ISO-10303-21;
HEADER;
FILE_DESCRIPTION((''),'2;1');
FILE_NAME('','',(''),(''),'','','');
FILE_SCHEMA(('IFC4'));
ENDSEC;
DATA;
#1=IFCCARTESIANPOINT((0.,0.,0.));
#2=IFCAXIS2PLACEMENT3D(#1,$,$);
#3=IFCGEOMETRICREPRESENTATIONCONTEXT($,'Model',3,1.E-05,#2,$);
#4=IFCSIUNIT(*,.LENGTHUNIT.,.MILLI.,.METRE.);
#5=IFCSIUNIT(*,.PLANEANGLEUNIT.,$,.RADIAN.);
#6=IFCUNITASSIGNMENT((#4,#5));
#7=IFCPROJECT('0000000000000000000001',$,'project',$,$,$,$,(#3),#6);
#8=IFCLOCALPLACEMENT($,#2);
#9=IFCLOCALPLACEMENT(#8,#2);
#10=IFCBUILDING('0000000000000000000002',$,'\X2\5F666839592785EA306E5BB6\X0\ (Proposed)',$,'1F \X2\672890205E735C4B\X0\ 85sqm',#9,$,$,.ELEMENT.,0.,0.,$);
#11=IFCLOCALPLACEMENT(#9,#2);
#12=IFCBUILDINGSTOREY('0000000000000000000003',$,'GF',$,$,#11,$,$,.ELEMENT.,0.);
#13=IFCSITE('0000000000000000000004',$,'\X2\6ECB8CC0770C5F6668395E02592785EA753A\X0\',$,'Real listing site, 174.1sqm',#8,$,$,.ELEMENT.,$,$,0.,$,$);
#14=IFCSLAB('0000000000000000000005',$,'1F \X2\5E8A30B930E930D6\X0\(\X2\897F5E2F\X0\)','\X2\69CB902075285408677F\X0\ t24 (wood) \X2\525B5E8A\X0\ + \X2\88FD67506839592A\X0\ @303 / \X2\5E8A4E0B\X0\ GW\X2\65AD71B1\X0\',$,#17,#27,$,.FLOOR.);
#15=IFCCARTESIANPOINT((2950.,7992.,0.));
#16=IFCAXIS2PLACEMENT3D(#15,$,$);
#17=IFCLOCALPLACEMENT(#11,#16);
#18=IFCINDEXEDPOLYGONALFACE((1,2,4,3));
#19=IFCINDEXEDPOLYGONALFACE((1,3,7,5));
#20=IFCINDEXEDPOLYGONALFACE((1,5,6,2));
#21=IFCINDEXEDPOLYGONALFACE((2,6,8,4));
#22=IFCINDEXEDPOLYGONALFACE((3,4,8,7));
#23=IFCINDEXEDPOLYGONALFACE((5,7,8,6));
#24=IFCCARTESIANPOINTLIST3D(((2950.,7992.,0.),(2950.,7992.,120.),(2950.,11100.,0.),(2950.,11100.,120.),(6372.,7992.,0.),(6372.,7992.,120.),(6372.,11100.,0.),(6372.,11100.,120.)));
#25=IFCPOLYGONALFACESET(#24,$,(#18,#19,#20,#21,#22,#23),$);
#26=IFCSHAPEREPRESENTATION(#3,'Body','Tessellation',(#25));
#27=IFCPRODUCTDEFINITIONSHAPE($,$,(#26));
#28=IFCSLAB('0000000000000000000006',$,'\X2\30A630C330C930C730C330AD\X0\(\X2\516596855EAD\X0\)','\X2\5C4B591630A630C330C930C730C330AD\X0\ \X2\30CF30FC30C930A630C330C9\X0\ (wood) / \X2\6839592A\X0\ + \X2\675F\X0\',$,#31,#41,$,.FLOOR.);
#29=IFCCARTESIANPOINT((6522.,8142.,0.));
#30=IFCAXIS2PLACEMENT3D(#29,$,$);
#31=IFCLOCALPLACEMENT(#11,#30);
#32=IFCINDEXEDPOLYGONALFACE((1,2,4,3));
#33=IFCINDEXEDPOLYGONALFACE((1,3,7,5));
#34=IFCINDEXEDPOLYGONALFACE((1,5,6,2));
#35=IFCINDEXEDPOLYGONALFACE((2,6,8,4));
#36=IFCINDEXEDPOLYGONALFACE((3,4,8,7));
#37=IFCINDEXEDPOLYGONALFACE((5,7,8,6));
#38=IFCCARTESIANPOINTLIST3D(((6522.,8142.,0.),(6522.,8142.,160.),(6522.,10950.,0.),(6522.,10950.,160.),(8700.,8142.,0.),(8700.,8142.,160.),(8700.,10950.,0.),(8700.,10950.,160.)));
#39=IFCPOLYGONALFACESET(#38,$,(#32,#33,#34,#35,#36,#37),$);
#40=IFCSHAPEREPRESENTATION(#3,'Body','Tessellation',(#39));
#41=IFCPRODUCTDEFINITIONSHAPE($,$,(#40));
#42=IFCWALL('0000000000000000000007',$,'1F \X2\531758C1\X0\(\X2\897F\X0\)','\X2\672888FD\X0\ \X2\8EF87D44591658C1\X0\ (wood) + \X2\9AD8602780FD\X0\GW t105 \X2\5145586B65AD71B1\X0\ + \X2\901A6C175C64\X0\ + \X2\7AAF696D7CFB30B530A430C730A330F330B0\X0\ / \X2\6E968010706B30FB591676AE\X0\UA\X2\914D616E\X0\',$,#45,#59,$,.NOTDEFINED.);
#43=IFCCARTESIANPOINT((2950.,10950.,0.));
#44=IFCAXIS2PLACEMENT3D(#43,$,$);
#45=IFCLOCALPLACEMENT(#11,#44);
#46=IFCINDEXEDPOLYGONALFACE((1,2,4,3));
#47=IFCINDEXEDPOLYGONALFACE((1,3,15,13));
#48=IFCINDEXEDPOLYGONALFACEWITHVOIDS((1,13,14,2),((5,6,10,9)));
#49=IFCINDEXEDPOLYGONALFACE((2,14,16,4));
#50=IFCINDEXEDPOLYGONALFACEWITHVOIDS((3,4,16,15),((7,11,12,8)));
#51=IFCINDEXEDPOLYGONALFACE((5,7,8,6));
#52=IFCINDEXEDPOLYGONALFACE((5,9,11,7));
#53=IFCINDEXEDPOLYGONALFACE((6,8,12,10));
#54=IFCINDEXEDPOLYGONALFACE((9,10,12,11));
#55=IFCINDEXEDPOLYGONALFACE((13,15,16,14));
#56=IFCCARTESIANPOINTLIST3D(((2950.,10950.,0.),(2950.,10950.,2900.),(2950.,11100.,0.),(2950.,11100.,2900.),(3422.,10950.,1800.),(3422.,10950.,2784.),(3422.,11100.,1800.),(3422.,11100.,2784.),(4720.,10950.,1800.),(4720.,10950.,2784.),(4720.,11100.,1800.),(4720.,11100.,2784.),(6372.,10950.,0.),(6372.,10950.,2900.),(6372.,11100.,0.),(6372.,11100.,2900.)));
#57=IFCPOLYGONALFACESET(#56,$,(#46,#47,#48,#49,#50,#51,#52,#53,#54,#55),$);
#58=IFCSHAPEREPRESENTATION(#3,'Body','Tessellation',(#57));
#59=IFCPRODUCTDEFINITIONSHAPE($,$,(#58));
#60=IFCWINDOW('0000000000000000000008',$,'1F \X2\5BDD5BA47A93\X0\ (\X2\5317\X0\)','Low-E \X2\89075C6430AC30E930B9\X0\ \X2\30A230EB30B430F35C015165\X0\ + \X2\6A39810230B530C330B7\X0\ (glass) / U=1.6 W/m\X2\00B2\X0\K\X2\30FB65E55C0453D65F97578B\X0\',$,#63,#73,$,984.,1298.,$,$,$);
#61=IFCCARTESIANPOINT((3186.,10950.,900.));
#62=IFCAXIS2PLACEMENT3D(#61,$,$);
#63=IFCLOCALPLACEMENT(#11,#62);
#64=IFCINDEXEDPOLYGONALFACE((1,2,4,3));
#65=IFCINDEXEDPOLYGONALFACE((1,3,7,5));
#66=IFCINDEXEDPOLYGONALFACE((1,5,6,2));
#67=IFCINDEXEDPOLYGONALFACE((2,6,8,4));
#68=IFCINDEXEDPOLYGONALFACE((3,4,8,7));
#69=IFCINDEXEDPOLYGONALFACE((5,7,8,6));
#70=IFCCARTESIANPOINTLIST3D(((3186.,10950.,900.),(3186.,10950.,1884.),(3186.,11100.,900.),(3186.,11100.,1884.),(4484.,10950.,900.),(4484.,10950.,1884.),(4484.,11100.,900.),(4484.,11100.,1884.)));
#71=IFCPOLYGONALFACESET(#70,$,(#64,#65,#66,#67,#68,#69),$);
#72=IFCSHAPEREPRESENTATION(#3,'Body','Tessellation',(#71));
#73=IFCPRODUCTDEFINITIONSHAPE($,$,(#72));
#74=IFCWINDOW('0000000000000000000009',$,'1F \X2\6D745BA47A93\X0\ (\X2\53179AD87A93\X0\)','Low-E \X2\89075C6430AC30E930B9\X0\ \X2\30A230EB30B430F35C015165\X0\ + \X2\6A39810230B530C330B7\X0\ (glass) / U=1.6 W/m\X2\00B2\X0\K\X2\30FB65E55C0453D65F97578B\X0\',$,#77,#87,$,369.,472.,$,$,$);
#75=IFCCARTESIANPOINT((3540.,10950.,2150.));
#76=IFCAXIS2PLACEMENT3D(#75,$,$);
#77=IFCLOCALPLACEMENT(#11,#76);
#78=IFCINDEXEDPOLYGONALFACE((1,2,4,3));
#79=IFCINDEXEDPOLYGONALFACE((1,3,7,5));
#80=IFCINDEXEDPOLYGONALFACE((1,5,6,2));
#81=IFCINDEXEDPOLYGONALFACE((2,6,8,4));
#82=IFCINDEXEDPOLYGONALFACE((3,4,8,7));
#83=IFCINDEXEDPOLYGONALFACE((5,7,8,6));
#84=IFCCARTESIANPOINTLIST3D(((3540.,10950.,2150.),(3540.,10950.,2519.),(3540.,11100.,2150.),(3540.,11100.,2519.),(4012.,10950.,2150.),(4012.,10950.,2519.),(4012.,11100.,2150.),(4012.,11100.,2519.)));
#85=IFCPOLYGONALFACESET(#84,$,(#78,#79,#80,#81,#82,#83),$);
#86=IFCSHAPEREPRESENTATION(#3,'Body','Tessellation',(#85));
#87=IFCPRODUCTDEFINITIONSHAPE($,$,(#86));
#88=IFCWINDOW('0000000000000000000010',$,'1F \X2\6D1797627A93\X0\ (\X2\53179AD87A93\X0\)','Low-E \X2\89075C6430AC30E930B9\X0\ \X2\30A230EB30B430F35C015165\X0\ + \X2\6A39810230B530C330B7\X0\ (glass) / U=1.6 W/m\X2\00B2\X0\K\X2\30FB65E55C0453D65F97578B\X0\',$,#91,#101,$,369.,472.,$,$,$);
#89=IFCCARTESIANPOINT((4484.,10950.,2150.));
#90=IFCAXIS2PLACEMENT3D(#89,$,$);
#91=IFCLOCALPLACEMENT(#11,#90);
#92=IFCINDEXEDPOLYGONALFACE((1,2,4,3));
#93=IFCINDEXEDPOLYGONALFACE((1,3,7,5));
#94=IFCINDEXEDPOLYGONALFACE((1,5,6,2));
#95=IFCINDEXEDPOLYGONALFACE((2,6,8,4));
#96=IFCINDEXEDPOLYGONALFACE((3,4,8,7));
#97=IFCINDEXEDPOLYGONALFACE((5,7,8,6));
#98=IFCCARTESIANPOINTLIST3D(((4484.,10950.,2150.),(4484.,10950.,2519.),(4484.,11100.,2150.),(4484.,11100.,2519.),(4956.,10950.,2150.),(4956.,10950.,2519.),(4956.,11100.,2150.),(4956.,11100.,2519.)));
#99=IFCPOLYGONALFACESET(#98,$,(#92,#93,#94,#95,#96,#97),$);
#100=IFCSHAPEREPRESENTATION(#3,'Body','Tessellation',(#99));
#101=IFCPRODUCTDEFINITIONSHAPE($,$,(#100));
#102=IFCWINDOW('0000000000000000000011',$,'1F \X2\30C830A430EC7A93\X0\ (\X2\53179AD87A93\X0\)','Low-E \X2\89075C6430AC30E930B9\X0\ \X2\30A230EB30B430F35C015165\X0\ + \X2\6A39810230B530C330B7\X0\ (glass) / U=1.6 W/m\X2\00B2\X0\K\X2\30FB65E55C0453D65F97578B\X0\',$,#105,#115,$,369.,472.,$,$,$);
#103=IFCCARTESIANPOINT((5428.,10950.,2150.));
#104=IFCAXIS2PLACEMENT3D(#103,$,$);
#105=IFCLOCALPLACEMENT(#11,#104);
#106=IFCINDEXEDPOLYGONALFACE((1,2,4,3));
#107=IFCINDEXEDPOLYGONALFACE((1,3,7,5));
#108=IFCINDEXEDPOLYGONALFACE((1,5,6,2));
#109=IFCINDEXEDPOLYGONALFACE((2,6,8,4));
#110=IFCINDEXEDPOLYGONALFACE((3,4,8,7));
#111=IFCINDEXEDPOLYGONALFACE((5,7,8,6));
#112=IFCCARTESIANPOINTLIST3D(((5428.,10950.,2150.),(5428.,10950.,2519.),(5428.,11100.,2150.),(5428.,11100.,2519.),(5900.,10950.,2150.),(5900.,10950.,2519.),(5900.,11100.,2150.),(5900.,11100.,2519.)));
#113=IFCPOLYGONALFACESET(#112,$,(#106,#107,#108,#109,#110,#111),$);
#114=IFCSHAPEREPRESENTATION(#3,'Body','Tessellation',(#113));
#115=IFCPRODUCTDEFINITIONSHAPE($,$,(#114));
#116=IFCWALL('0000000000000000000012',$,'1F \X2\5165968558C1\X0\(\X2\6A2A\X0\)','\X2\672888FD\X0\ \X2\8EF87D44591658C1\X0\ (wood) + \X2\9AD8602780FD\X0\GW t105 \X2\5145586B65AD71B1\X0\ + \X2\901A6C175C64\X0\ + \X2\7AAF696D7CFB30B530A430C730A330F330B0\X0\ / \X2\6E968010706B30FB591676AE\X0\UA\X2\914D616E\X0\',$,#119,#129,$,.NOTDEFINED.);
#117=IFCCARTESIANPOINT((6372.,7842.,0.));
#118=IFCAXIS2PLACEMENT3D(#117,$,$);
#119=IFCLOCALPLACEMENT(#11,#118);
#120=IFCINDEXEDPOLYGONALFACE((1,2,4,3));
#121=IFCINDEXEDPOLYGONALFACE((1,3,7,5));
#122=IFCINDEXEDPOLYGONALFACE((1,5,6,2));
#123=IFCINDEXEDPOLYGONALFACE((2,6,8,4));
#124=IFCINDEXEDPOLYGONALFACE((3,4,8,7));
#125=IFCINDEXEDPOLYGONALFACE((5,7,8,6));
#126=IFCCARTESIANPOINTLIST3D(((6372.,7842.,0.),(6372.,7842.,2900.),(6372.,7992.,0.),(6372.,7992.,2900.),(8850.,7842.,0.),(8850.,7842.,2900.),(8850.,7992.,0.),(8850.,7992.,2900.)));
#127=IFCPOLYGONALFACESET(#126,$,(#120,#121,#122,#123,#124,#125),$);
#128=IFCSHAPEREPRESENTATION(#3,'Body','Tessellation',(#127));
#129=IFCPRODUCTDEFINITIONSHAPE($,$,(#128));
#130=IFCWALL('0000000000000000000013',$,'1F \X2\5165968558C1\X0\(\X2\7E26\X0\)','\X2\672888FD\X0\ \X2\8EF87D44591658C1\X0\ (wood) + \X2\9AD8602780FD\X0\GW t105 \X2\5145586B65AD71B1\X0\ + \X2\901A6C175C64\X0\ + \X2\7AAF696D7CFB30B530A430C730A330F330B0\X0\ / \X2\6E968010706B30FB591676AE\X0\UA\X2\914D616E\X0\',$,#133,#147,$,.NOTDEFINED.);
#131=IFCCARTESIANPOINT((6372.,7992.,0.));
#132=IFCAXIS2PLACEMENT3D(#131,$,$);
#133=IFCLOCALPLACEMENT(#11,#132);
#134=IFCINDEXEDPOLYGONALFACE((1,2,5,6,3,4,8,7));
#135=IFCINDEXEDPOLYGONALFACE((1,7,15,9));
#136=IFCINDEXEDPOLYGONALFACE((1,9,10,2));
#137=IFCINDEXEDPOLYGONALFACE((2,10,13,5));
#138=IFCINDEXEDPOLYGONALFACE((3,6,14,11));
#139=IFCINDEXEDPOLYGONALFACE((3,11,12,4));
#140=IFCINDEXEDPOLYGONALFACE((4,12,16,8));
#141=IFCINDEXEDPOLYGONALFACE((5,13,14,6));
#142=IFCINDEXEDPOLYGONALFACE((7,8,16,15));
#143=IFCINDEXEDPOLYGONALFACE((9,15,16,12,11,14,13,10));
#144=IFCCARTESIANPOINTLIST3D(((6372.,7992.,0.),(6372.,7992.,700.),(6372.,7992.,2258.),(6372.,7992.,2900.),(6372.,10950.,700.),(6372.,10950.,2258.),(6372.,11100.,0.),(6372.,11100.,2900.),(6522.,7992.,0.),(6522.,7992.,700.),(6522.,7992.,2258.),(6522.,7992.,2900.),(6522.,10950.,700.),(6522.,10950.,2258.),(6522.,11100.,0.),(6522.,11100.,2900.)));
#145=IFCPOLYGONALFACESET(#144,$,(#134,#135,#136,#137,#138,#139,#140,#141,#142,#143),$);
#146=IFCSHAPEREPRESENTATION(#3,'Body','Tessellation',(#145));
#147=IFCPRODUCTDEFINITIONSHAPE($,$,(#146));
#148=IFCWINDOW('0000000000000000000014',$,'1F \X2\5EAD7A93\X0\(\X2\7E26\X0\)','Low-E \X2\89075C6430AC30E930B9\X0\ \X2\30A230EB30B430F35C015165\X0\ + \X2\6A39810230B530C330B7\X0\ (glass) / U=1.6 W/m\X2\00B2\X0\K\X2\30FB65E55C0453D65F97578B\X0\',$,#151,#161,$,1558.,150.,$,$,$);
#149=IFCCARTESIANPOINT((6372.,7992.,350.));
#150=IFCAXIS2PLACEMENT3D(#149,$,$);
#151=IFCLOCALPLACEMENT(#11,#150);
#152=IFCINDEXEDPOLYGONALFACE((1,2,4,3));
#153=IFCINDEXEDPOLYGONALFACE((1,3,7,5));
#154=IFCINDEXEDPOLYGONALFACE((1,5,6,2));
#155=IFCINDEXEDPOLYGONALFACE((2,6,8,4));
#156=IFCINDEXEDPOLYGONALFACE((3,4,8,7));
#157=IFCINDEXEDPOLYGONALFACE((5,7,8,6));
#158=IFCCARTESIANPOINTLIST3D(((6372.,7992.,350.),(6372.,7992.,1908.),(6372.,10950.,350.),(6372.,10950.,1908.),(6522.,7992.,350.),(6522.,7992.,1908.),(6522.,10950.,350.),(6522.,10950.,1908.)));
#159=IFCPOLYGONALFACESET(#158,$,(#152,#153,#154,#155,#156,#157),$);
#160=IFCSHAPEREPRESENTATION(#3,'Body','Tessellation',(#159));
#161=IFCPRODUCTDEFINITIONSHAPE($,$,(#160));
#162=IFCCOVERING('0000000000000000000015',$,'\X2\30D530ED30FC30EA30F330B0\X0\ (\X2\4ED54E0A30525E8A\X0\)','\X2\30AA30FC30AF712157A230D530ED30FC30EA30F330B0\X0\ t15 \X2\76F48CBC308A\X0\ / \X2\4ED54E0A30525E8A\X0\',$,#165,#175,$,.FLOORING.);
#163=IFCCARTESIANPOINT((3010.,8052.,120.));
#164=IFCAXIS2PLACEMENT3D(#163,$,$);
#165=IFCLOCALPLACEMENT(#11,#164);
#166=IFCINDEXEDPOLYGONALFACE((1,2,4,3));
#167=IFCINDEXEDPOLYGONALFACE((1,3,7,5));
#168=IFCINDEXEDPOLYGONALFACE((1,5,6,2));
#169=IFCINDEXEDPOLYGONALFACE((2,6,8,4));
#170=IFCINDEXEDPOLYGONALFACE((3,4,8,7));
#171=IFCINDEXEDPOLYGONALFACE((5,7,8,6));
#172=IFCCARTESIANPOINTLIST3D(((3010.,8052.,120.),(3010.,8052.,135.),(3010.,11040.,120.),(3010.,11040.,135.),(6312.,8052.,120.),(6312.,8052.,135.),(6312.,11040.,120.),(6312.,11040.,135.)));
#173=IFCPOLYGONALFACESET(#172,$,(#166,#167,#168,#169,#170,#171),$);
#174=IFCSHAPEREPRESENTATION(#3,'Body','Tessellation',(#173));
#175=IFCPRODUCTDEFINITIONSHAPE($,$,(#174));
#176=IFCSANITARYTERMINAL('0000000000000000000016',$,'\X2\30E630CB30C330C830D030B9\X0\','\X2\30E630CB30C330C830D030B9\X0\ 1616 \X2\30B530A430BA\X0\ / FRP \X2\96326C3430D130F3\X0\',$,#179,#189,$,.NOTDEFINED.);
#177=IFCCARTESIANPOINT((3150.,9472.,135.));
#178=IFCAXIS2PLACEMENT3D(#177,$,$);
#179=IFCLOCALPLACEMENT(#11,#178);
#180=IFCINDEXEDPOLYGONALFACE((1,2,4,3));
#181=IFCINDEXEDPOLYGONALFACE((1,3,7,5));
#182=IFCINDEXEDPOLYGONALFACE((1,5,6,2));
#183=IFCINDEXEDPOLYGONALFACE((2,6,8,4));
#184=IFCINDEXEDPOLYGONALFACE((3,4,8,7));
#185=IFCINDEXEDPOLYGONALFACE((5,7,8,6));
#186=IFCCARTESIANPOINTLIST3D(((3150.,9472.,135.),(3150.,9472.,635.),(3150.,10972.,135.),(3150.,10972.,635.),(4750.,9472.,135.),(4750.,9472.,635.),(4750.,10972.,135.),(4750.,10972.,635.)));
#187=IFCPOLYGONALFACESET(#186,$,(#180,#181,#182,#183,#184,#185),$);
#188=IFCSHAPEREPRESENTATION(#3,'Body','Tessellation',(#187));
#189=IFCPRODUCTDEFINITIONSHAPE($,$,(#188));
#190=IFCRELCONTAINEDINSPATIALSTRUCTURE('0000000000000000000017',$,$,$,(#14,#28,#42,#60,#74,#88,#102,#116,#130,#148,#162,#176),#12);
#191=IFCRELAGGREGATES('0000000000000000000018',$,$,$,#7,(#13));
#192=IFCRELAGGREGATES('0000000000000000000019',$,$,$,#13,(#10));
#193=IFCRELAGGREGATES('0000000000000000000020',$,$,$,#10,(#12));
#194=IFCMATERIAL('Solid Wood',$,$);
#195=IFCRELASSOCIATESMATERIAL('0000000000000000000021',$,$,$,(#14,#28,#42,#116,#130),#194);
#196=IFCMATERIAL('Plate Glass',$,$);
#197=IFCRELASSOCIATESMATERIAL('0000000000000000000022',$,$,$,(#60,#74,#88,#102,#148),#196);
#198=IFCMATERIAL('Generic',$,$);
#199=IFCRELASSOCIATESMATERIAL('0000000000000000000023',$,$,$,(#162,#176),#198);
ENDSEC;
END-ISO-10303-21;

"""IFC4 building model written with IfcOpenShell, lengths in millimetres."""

from ifc_helpers import new_model, si_unit, frame, frame_2d, origin, place, context, project, spatial, rectangle, extrude, material, element, fill, save


model = new_model("IFC4")

# Units and contexts
model_context = context("Model", 3, precision=1e-05, world=origin())
ifc_project = project(units=[si_unit("LENGTHUNIT", "METRE", prefix="MILLI"), si_unit("PLANEANGLEUNIT", "RADIAN")], contexts=[model_context])

# Site, building, storey
site_placement = place(None, origin())
site = spatial("IfcSite", under=ifc_project, at=site_placement, Name="滋賀県彦根市大藪町", ObjectType="Real listing site, 174.1sqm", CompositionType="ELEMENT", RefElevation=0.0)
building_placement = place(site_placement, origin())
building = spatial("IfcBuilding", under=site, at=building_placement, Name="彦根大藪の家 (Proposed)", ObjectType="1F 木造平屋 85sqm", CompositionType="ELEMENT", ElevationOfRefHeight=0.0, ElevationOfTerrain=0.0)
storey_placement = place(building_placement, origin())
storey = spatial("IfcBuildingStorey", under=building, at=storey_placement, Name="GF", CompositionType="ELEMENT", Elevation=0.0)

# Slabs
ifc_material_1 = material(Name="Solid Wood")
slab_1_placement = place(storey_placement, frame((2950.0, 7992.0, 0.0)))
element("IfcSlab", 1, at=slab_1_placement, inside=storey, material=ifc_material_1, Name="1F 床スラブ(西帯)", Description="構造用合板 t24 (wood) 剛床 + 製材根太 @303 / 床下 GW断熱", PredefinedType="FLOOR", context=model_context, shape_type="SweptSolid", body=[
    extrude(rectangle(XDim=3422.0, YDim=3108.0, at=frame_2d((1711.0, 1554.0))), frame((2950.0, 7992.0, 0.0)), (0.0, 0.0, 1.0), 120.0),
])
slab_2_placement = place(storey_placement, frame((6522.0, 8142.0, 0.0)))
element("IfcSlab", 2, at=slab_2_placement, inside=storey, material=ifc_material_1, Name="ウッドデッキ(入隅庭)", Description="屋外ウッドデッキ ハードウッド (wood) / 根太 + 束", PredefinedType="FLOOR", context=model_context, shape_type="SweptSolid", body=[
    extrude(rectangle(XDim=2178.0, YDim=2808.0, at=frame_2d((1089.0, 1404.0))), frame((6522.0, 8142.0, 0.0)), (0.0, 0.0, 1.0), 160.0),
])

# Wall, openings, windows
wall_1_placement = place(storey_placement, frame((2950.0, 10950.0, 0.0)))
wall_1 = element("IfcWall", 3, at=wall_1_placement, inside=storey, material=ifc_material_1, Name="1F 北壁(西)", Description="木製 軸組外壁 (wood) + 高性能GW t105 充填断熱 + 通気層 + 窯業系サイディング / 準耐火・外皮UA配慮", PredefinedType="NOTDEFINED", context=model_context, shape_type="SweptSolid", body=[
    extrude(rectangle(XDim=3422.0, YDim=150.0, at=frame_2d((1711.0, 75.0))), frame((2950.0, 10950.0, 0.0)), (0.0, 0.0, 1.0), 2900.0),
])
opening_1_placement = place(storey_placement, frame((3186.0, 10950.0, 900.0)))
opening_1 = element("IfcOpeningElement", 4, at=opening_1_placement, cuts=wall_1, PredefinedType="NOTDEFINED", context=model_context, shape_type="SweptSolid", body=[
    extrude(rectangle(XDim=1298.0, YDim=150.0, at=frame_2d((649.0, 75.0))), frame((3186.0, 10950.0, 900.0)), (0.0, 0.0, 1.0), 984.0),
])
opening_2_placement = place(storey_placement, frame((3540.0, 10950.0, 2150.0)))
opening_2 = element("IfcOpeningElement", 5, at=opening_2_placement, cuts=wall_1, PredefinedType="NOTDEFINED", context=model_context, shape_type="SweptSolid", body=[
    extrude(rectangle(XDim=472.0, YDim=150.0, at=frame_2d((236.0, 75.0))), frame((3540.0, 10950.0, 2150.0)), (0.0, 0.0, 1.0), 369.0),
])
opening_3_placement = place(storey_placement, frame((4484.0, 10950.0, 2150.0)))
opening_3 = element("IfcOpeningElement", 6, at=opening_3_placement, cuts=wall_1, PredefinedType="NOTDEFINED", context=model_context, shape_type="SweptSolid", body=[
    extrude(rectangle(XDim=472.0, YDim=150.0, at=frame_2d((236.0, 75.0))), frame((4484.0, 10950.0, 2150.0)), (0.0, 0.0, 1.0), 369.0),
])
opening_4_placement = place(storey_placement, frame((5428.0, 10950.0, 2150.0)))
opening_4 = element("IfcOpeningElement", 7, at=opening_4_placement, cuts=wall_1, PredefinedType="NOTDEFINED", context=model_context, shape_type="SweptSolid", body=[
    extrude(rectangle(XDim=472.0, YDim=150.0, at=frame_2d((236.0, 75.0))), frame((5428.0, 10950.0, 2150.0)), (0.0, 0.0, 1.0), 369.0),
])
ifc_material_2 = material(Name="Plate Glass")
window_1_placement = place(storey_placement, frame((3186.0, 10950.0, 900.0)))
window_1 = element("IfcWindow", 8, at=window_1_placement, inside=storey, material=ifc_material_2, Name="1F 寝室窓 (北)", Description="Low-E 複層ガラス アルゴン封入 + 樹脂サッシ (glass) / U=1.6 W/m²K・日射取得型", OverallHeight=984.0, OverallWidth=1298.0, context=model_context, shape_type="SweptSolid", body=[
    extrude(rectangle(XDim=1298.0, YDim=150.0, at=frame_2d((649.0, 75.0))), frame((3186.0, 10950.0, 900.0)), (0.0, 0.0, 1.0), 984.0),
])
fill(opening_1, window_1)
window_2_placement = place(storey_placement, frame((3540.0, 10950.0, 2150.0)))
window_2 = element("IfcWindow", 9, at=window_2_placement, inside=storey, material=ifc_material_2, Name="1F 浴室窓 (北高窓)", Description="Low-E 複層ガラス アルゴン封入 + 樹脂サッシ (glass) / U=1.6 W/m²K・日射取得型", OverallHeight=369.0, OverallWidth=472.0, context=model_context, shape_type="SweptSolid", body=[
    extrude(rectangle(XDim=472.0, YDim=150.0, at=frame_2d((236.0, 75.0))), frame((3540.0, 10950.0, 2150.0)), (0.0, 0.0, 1.0), 369.0),
])
fill(opening_2, window_2)
window_3_placement = place(storey_placement, frame((4484.0, 10950.0, 2150.0)))
window_3 = element("IfcWindow", 10, at=window_3_placement, inside=storey, material=ifc_material_2, Name="1F 洗面窓 (北高窓)", Description="Low-E 複層ガラス アルゴン封入 + 樹脂サッシ (glass) / U=1.6 W/m²K・日射取得型", OverallHeight=369.0, OverallWidth=472.0, context=model_context, shape_type="SweptSolid", body=[
    extrude(rectangle(XDim=472.0, YDim=150.0, at=frame_2d((236.0, 75.0))), frame((4484.0, 10950.0, 2150.0)), (0.0, 0.0, 1.0), 369.0),
])
fill(opening_3, window_3)
window_4_placement = place(storey_placement, frame((5428.0, 10950.0, 2150.0)))
window_4 = element("IfcWindow", 11, at=window_4_placement, inside=storey, material=ifc_material_2, Name="1F トイレ窓 (北高窓)", Description="Low-E 複層ガラス アルゴン封入 + 樹脂サッシ (glass) / U=1.6 W/m²K・日射取得型", OverallHeight=369.0, OverallWidth=472.0, context=model_context, shape_type="SweptSolid", body=[
    extrude(rectangle(XDim=472.0, YDim=150.0, at=frame_2d((236.0, 75.0))), frame((5428.0, 10950.0, 2150.0)), (0.0, 0.0, 1.0), 369.0),
])
fill(opening_4, window_4)

# Wall
wall_2_placement = place(storey_placement, frame((6372.0, 7842.0, 0.0)))
element("IfcWall", 12, at=wall_2_placement, inside=storey, material=ifc_material_1, Name="1F 入隅壁(横)", Description="木製 軸組外壁 (wood) + 高性能GW t105 充填断熱 + 通気層 + 窯業系サイディング / 準耐火・外皮UA配慮", PredefinedType="NOTDEFINED", context=model_context, shape_type="SweptSolid", body=[
    extrude(rectangle(XDim=2478.0, YDim=150.0, at=frame_2d((1239.0, 75.0))), frame((6372.0, 7842.0, 0.0)), (0.0, 0.0, 1.0), 2900.0),
])

# Wall, opening, window
wall_3_placement = place(storey_placement, frame((6372.0, 7992.0, 0.0)))
wall_3 = element("IfcWall", 13, at=wall_3_placement, inside=storey, material=ifc_material_1, Name="1F 入隅壁(縦)", Description="木製 軸組外壁 (wood) + 高性能GW t105 充填断熱 + 通気層 + 窯業系サイディング / 準耐火・外皮UA配慮", PredefinedType="NOTDEFINED", context=model_context, shape_type="SweptSolid", body=[
    extrude(rectangle(XDim=150.0, YDim=3108.0, at=frame_2d((75.0, 1554.0))), frame((6372.0, 7992.0, 0.0)), (0.0, 0.0, 1.0), 2900.0),
])
opening_5_placement = place(storey_placement, frame((6372.0, 7992.0, 350.0)))
opening_5 = element("IfcOpeningElement", 14, at=opening_5_placement, cuts=wall_3, PredefinedType="NOTDEFINED", context=model_context, shape_type="SweptSolid", body=[
    extrude(rectangle(XDim=150.0, YDim=2958.0, at=frame_2d((75.0, 1479.0))), frame((6372.0, 7992.0, 350.0)), (0.0, 0.0, 1.0), 1558.0),
])
window_5_placement = place(storey_placement, frame((6372.0, 7992.0, 350.0)))
window_5 = element("IfcWindow", 15, at=window_5_placement, inside=storey, material=ifc_material_2, Name="1F 庭窓(縦)", Description="Low-E 複層ガラス アルゴン封入 + 樹脂サッシ (glass) / U=1.6 W/m²K・日射取得型", OverallHeight=1558.0, OverallWidth=150.0, context=model_context, shape_type="SweptSolid", body=[
    extrude(rectangle(XDim=150.0, YDim=2958.0, at=frame_2d((75.0, 1479.0))), frame((6372.0, 7992.0, 350.0)), (0.0, 0.0, 1.0), 1558.0),
])
fill(opening_5, window_5)

# Covering
ifc_material_3 = material(Name="Generic")
covering_placement = place(storey_placement, frame((3010.0, 8052.0, 120.0)))
element("IfcCovering", 16, at=covering_placement, inside=storey, material=ifc_material_3, Name="フローリング (仕上げ床)", Description="オーク無垢フローリング t15 直貼り / 仕上げ床", PredefinedType="FLOORING", context=model_context, shape_type="SweptSolid", body=[
    extrude(rectangle(XDim=3302.0, YDim=2988.0, at=frame_2d((1651.0, 1494.0))), frame((3010.0, 8052.0, 120.0)), (0.0, 0.0, 1.0), 15.0),
])

# Sanitary terminal
sanitary_terminal_1_placement = place(storey_placement, frame((3150.0, 9472.0, 135.0)))
element("IfcSanitaryTerminal", 17, at=sanitary_terminal_1_placement, inside=storey, material=ifc_material_3, Name="ユニットバス", Description="ユニットバス 1616 サイズ / FRP 防水パン", PredefinedType="NOTDEFINED", context=model_context, shape_type="SweptSolid", body=[
    extrude(rectangle(XDim=1600.0, YDim=1500.0, at=frame_2d((800.0, 750.0))), frame((3150.0, 9472.0, 135.0)), (0.0, 0.0, 1.0), 500.0),
])

save(model, "model.ifc")
